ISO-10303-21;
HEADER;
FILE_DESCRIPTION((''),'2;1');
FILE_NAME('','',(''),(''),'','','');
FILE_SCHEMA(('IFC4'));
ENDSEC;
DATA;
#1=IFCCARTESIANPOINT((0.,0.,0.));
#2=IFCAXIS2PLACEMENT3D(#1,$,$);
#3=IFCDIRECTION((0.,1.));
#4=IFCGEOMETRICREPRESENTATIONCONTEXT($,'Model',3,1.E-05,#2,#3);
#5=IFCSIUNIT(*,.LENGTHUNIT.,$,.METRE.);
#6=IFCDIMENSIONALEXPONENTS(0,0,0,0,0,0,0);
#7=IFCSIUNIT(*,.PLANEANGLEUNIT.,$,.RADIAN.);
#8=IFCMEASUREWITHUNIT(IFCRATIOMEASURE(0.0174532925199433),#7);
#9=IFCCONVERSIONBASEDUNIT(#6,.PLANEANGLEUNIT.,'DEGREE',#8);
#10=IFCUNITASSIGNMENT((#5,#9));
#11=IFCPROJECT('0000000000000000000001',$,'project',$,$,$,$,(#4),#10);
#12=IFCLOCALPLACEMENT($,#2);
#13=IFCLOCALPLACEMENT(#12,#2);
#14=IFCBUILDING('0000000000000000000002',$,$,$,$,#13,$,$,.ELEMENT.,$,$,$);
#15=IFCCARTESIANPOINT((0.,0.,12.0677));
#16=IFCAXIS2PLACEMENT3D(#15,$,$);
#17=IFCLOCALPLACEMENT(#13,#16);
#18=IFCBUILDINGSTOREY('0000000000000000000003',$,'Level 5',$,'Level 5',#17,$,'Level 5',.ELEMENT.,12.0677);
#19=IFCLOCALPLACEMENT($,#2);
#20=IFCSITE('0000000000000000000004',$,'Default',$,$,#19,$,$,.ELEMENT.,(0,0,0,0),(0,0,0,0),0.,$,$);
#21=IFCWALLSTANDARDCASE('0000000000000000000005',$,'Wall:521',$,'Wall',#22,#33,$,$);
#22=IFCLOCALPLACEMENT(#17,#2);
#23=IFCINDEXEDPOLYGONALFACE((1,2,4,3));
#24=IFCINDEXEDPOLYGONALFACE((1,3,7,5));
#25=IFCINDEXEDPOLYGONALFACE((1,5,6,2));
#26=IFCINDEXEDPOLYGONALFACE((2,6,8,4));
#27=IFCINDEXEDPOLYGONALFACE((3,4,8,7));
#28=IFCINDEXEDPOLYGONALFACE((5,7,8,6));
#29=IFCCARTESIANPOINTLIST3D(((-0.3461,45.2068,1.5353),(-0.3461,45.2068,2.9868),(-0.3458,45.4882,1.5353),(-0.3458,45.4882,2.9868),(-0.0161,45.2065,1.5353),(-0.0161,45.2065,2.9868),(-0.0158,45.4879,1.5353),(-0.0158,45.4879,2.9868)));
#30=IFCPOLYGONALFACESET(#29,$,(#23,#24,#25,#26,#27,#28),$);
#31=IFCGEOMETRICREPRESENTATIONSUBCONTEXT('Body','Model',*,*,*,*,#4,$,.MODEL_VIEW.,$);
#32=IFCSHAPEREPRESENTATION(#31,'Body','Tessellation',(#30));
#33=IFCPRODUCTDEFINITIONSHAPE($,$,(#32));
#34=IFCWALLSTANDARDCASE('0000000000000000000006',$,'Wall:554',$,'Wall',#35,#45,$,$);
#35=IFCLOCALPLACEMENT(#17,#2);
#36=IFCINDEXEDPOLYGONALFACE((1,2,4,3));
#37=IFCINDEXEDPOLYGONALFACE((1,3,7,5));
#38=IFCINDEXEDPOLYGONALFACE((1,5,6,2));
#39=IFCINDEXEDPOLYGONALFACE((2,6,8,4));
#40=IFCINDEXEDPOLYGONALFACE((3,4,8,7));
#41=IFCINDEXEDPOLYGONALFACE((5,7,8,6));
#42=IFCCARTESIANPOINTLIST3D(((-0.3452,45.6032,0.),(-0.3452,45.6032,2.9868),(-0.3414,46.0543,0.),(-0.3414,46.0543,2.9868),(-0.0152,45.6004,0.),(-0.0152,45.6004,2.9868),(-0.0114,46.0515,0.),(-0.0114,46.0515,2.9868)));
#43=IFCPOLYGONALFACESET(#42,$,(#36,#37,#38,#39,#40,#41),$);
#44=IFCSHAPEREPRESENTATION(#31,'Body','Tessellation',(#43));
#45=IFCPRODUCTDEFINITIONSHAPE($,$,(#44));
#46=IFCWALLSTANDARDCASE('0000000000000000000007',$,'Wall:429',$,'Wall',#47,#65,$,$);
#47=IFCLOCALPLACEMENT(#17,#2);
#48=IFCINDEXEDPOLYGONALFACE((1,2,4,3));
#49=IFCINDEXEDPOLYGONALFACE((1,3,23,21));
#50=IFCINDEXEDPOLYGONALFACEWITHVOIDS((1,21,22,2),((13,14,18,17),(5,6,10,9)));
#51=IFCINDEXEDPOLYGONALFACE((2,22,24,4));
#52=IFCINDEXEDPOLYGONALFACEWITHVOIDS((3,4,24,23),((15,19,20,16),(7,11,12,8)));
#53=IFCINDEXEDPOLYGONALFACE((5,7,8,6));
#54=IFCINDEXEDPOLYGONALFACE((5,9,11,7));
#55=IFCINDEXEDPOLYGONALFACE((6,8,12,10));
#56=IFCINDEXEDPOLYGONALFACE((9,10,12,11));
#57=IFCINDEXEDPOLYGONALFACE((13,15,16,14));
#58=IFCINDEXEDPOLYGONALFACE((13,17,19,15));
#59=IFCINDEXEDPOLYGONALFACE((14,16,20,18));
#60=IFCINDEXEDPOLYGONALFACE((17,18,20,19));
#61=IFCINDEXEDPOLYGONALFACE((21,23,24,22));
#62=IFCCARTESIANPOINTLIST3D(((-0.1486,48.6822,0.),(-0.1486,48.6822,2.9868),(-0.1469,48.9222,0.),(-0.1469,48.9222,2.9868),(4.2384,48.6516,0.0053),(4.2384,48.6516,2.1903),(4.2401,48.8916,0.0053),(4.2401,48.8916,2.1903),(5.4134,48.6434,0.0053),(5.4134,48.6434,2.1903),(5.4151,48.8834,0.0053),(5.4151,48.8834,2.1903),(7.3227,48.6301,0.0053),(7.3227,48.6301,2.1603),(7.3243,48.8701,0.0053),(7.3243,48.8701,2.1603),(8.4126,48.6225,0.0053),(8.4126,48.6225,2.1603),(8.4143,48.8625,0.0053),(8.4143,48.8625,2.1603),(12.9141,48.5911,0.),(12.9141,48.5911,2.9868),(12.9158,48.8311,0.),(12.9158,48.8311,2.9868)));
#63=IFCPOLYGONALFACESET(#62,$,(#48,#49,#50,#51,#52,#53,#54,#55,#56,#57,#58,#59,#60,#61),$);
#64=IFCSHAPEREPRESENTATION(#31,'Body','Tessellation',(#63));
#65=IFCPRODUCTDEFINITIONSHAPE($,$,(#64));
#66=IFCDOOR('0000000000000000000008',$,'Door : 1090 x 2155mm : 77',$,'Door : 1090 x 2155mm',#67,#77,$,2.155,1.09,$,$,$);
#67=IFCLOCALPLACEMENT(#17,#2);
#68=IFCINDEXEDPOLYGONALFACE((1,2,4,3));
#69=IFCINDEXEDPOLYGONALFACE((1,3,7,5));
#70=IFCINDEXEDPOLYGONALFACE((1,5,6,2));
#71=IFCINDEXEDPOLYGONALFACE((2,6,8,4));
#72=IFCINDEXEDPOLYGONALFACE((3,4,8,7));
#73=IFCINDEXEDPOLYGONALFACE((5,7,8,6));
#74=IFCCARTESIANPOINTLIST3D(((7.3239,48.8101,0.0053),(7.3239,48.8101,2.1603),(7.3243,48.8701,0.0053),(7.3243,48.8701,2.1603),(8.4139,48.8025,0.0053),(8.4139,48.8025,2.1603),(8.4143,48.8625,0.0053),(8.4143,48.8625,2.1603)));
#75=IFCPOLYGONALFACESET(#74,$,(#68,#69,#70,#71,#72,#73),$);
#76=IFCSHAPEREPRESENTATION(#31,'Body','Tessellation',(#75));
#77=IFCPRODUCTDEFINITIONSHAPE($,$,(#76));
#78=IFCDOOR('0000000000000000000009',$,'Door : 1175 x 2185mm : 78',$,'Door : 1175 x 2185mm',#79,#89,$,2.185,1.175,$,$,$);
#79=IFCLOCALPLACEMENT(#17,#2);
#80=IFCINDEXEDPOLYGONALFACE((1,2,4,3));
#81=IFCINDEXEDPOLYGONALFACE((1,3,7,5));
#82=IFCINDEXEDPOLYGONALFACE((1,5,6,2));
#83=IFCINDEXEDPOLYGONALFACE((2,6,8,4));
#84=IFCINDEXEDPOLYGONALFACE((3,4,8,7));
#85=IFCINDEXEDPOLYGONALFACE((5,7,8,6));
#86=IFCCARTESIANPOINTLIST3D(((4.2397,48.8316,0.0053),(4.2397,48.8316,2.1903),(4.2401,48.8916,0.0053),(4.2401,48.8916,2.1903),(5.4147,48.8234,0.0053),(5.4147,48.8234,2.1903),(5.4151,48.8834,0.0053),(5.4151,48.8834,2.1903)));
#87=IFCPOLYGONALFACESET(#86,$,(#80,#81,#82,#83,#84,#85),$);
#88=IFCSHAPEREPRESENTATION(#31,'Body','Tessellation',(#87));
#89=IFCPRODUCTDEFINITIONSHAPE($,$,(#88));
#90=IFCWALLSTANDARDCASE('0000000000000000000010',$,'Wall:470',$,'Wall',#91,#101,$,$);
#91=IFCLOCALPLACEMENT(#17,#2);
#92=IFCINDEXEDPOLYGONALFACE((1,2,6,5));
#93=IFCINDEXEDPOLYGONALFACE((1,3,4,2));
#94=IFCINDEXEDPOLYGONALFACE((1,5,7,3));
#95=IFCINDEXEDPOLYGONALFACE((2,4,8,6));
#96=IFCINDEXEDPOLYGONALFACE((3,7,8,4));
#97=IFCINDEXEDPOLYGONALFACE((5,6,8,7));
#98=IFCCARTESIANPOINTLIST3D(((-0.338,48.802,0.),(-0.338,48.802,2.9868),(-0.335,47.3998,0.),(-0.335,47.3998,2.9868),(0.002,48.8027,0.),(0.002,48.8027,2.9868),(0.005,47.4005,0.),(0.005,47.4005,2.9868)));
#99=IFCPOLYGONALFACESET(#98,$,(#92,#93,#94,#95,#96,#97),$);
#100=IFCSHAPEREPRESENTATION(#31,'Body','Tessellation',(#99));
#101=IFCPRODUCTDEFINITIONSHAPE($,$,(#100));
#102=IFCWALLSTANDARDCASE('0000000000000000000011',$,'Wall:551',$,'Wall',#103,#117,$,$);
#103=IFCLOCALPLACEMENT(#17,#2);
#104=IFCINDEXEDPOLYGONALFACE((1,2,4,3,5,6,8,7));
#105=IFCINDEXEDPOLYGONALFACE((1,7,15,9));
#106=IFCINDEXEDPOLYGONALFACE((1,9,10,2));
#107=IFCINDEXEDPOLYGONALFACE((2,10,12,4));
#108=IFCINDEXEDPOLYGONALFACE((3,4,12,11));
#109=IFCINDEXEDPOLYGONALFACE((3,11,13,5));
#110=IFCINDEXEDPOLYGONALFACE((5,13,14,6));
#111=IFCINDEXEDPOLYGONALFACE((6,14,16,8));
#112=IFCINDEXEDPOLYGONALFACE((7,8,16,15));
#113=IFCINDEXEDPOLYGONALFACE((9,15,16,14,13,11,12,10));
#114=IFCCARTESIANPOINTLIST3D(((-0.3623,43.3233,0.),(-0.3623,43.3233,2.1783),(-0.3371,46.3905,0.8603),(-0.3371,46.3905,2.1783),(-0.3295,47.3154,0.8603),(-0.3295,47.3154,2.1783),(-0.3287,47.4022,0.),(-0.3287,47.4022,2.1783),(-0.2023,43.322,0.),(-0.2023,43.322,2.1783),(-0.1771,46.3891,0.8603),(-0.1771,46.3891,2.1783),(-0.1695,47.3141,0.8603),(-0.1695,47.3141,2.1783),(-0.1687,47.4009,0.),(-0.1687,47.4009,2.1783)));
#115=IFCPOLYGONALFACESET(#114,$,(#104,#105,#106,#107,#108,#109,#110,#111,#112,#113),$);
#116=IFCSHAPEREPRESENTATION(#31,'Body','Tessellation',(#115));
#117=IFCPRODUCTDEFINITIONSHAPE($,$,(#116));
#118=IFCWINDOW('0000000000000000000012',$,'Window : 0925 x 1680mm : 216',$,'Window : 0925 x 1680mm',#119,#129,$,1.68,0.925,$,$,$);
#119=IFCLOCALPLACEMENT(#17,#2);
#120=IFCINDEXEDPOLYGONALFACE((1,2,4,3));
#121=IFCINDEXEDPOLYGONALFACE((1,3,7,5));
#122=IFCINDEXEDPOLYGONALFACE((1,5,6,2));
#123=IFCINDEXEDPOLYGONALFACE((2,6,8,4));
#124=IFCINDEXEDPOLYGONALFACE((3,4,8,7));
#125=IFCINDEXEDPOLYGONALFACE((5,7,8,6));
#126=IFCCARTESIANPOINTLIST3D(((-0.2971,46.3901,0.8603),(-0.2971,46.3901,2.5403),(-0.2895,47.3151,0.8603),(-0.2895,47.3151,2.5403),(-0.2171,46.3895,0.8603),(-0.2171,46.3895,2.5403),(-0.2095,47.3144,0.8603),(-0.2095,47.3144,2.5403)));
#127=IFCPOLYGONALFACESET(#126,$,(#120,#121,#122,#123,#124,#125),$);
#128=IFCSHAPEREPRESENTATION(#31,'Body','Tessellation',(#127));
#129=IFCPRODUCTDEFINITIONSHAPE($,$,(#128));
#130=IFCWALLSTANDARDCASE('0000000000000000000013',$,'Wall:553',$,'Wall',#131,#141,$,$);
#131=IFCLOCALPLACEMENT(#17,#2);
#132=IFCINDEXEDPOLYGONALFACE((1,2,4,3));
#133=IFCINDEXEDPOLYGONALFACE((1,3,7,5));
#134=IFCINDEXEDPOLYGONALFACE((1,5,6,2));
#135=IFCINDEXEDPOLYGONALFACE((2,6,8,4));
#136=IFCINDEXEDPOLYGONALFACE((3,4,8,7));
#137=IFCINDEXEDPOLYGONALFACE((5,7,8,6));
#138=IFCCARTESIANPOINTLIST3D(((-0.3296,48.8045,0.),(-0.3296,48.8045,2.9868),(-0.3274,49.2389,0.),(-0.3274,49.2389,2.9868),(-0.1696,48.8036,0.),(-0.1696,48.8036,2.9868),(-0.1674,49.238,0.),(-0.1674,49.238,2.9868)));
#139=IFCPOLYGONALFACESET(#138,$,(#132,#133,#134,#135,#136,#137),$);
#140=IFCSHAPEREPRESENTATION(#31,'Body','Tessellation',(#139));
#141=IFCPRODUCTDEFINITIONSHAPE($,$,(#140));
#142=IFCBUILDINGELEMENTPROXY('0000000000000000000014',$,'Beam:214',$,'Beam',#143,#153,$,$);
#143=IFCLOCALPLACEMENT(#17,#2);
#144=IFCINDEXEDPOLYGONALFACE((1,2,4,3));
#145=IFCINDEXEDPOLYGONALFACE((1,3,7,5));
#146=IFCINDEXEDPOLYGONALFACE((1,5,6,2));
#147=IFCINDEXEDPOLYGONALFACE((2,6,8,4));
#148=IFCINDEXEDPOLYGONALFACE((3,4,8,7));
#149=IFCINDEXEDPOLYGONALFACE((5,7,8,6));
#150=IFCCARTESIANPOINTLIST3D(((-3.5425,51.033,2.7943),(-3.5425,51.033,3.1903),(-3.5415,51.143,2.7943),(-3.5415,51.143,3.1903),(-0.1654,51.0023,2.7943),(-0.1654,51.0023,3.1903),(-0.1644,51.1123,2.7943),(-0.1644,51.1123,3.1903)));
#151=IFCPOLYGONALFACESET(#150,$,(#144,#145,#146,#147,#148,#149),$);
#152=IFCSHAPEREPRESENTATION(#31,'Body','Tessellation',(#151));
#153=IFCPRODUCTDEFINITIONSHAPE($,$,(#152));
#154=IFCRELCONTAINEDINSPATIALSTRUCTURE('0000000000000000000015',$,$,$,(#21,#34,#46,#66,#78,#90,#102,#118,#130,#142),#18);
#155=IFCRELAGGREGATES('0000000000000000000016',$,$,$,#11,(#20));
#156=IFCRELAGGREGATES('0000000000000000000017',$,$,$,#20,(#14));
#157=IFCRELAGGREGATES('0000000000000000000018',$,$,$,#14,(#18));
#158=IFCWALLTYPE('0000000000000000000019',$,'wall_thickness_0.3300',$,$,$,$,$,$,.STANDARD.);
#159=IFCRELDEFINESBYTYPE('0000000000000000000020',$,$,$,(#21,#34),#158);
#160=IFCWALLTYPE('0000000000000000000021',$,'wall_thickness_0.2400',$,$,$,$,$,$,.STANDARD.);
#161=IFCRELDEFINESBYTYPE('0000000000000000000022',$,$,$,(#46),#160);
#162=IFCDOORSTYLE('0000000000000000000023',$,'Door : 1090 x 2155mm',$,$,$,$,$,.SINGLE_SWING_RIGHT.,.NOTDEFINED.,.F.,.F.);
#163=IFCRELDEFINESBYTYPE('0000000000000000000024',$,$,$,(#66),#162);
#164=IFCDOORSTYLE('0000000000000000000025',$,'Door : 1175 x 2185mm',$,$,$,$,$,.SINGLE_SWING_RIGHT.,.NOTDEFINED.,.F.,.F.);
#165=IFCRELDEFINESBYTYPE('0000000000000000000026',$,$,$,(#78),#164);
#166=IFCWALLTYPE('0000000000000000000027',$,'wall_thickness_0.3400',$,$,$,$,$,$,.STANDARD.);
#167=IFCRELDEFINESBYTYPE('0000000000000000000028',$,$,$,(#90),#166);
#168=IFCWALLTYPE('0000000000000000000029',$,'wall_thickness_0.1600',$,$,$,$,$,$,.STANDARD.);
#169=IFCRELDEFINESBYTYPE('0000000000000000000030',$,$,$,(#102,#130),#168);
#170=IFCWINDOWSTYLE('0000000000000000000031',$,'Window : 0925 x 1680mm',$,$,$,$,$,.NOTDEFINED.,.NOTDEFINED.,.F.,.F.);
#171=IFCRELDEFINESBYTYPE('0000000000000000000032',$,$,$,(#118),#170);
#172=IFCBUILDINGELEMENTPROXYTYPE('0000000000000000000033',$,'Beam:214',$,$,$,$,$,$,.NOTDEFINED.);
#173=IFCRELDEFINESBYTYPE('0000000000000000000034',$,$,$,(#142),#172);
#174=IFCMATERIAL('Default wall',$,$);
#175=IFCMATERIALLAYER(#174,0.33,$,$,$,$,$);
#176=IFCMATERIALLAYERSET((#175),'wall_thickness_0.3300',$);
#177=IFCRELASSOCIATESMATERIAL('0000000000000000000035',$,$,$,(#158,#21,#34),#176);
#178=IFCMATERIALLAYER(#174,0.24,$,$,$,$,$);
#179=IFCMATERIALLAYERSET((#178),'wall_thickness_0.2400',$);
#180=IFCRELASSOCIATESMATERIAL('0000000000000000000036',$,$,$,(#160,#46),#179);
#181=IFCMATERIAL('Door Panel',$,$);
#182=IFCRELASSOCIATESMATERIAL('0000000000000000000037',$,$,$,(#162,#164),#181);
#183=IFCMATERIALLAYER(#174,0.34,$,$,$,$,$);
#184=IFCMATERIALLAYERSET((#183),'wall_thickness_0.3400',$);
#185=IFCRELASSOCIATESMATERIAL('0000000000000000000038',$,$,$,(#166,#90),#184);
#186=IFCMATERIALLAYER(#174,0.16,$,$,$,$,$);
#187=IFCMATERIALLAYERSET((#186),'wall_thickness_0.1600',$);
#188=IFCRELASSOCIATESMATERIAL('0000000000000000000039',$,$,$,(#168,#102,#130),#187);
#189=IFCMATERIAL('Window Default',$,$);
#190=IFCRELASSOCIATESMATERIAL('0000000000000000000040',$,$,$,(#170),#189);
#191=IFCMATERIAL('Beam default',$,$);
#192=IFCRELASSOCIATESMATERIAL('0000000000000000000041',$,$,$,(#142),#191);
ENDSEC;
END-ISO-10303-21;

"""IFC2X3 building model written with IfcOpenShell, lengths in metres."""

from ifc_helpers import new_model, entity, si_unit, converted_unit, direction, frame, frame_2d, origin, origin_2d_with_axis, place, context, subcontext, project, spatial, polyline, rectangle, outline, extrude, source, transform, mapped, material, layer, layer_set, layer_usage, type_object, type_shapes, element, fill, save


model = new_model("IFC2X3")

# Units and contexts
model_context = context("Model", 3, precision=1e-05, world=origin(), true_north=direction((0.0, 1.0)))
body_context = subcontext(model_context, "Body", "Model", "MODEL_VIEW")
ifc_project = project(units=[si_unit("LENGTHUNIT", "METRE"), converted_unit("PLANEANGLEUNIT", "DEGREE", entity("IfcRatioMeasure", 0.0174532925199433), si_unit("PLANEANGLEUNIT", "RADIAN"), dimensions=[0, 0, 0, 0, 0, 0, 0])], contexts=[model_context])

# Site, building, storey
site_placement = place(None, origin())
site = spatial("IfcSite", under=ifc_project, at=site_placement, Name="Default", CompositionType="ELEMENT", RefLatitude=(0, 0, 0, 0), RefLongitude=(0, 0, 0, 0), RefElevation=0.0)
placement_1 = place(None, origin())
building_placement = place(placement_1, origin())
building = spatial("IfcBuilding", under=site, at=building_placement, CompositionType="ELEMENT")
storey_placement = place(building_placement, frame((0.0, 0.0, 12.0677)))
storey = spatial("IfcBuildingStorey", under=building, at=storey_placement, Name="Level 5", ObjectType="Level 5", LongName="Level 5", CompositionType="ELEMENT", Elevation=12.0677)

# Shared definitions
ifc_material_1 = material(Name="Default wall")

# Shared definitions
ifc_layer_1 = layer(ifc_material_1, 0.33)
ifc_layer_set_1 = layer_set([ifc_layer_1], Name="wall_thickness_0.3300")
ifc_layer_usage_1 = layer_usage(ifc_layer_set_1, "AXIS2", "POSITIVE", -0.165)
wall_type_1 = type_object("IfcWallType", Name="wall_thickness_0.3300", PredefinedType="STANDARD", material=ifc_layer_set_1)
ifc_material_2 = material(Name="Window Default")

# Walls
placement_2 = place(building_placement, frame((0.0, 0.0, 13.603)))
wall_1_placement = place(placement_2, frame((-0.1808, 45.488, 0.0), z_axis=(0.0, 0.0, 1.0), x_axis=(-0.001081, -0.999999, 0.0)))
element("IfcWallStandardCase", 1, at=wall_1_placement, inside=storey, type_object=wall_type_1, material=ifc_layer_usage_1, Name="Wall:521", ObjectType="Wall", context=body_context, shape_type="SweptSolid", body=[
    extrude(outline(polyline([(0.2814, -0.165), (0.2814, 0.165), (0.0, 0.165), (0.0, -0.165), (0.2814, -0.165)])), origin(), (0.0, 0.0, 1.0), 1.4515),
])
wall_2_placement = place(storey_placement, frame((-0.1764, 46.0529, 0.0), z_axis=(0.0, 0.0, 1.0), x_axis=(-0.008507, -0.999964, 0.0)))
element("IfcWallStandardCase", 2, at=wall_2_placement, inside=storey, type_object=wall_type_1, material=ifc_layer_usage_1, Name="Wall:554", ObjectType="Wall", context=body_context, shape_type="SweptSolid", body=[
    extrude(outline(polyline([(0.4511, -0.165), (0.4511, 0.165), (0.0, 0.165), (0.0, -0.165), (0.4511, -0.165)])), origin(), (0.0, 0.0, 1.0), 2.9868),
])

# Wall, openings, doors
ifc_layer_2 = layer(ifc_material_1, 0.24)
ifc_layer_set_2 = layer_set([ifc_layer_2], Name="wall_thickness_0.2400")
ifc_layer_usage_2 = layer_usage(ifc_layer_set_2, "AXIS2", "POSITIVE", -0.12)
wall_type_2 = type_object("IfcWallType", Name="wall_thickness_0.2400", PredefinedType="STANDARD", material=ifc_layer_set_2)
wall_3_placement = place(storey_placement, frame((-0.1477, 48.8022, 0.0), z_axis=(0.0, 0.0, 1.0), x_axis=(0.999976, -0.006979, 0.0)))
wall_3 = element("IfcWallStandardCase", 3, at=wall_3_placement, inside=storey, type_object=wall_type_2, material=ifc_layer_usage_2, Name="Wall:429", ObjectType="Wall", context=body_context, shape_type="SweptSolid", body=[
    extrude(outline(polyline([(13.063, -0.12), (13.063, 0.12), (0.0, 0.12), (0.0, -0.12), (13.063, -0.12)])), origin(), (0.0, 0.0, 1.0), 2.9868),
])
opening_1_placement = place(wall_3_placement, frame((7.4714, -0.12, 0.0053)))
opening_1 = element("IfcOpeningElement", 4, at=opening_1_placement, cuts=wall_3, ObjectType="Opening", context=body_context, shape_type="SweptSolid", body=[
    extrude(rectangle(XDim=1.09, YDim=2.155, at=frame_2d((1.0775, 0.545), x_axis=(0.0, 1.0))), frame((0.0, 0.0, 0.0), z_axis=(0.0, 1.0, 0.0), x_axis=(0.0, 0.0, 1.0)), (0.0, 0.0, 1.0), 0.24),
])
opening_2_placement = place(wall_3_placement, frame((4.3871, -0.12, 0.0053)))
opening_2 = element("IfcOpeningElement", 5, at=opening_2_placement, cuts=wall_3, ObjectType="Opening", context=body_context, shape_type="SweptSolid", body=[
    extrude(rectangle(XDim=1.175, YDim=2.185, at=frame_2d((1.0925, 0.5875), x_axis=(0.0, 1.0))), frame((0.0, 0.0, 0.0), z_axis=(0.0, 1.0, 0.0), x_axis=(0.0, 0.0, 1.0)), (0.0, 0.0, 1.0), 0.24),
])
ifc_material_3 = material(Name="Door Panel")
door_style_1 = type_object("IfcDoorStyle", Name="Door : 1090 x 2155mm", ConstructionType="NOTDEFINED", OperationType="SINGLE_SWING_RIGHT", ParameterTakesPrecedence=False, Sizeable=False, material=ifc_material_3)
shared_shape_1 = source(origin(), body_context, "Body", "SweptSolid", [
    extrude(rectangle(XDim=0.06, YDim=1.09, at=origin_2d_with_axis()), frame((0.545, 0.21, 0.0), z_axis=(0.0, 0.0, 1.0), x_axis=(0.0, 1.0, 0.0)), (0.0, 0.0, 1.0), 2.155),
])
type_shapes(door_style_1, [shared_shape_1])
door_1_placement = place(opening_1_placement, origin())
door_1 = element("IfcDoor", 6, at=door_1_placement, inside=storey, type_object=door_style_1, Name="Door : 1090 x 2155mm : 77", ObjectType="Door : 1090 x 2155mm", OverallHeight=2.155, OverallWidth=1.09, context=body_context, shape_type="MappedRepresentation", body=[
    mapped(shared_shape_1, transform((0.0, 0.0, 0.0), scale=1.0)),
])
fill(opening_1, door_1)
door_style_2 = type_object("IfcDoorStyle", Name="Door : 1175 x 2185mm", ConstructionType="NOTDEFINED", OperationType="SINGLE_SWING_RIGHT", ParameterTakesPrecedence=False, Sizeable=False, material=ifc_material_3)
shared_shape_2 = source(origin(), body_context, "Body", "SweptSolid", [
    extrude(rectangle(XDim=0.06, YDim=1.175, at=origin_2d_with_axis()), frame((0.5875, 0.21, 0.0), z_axis=(0.0, 0.0, 1.0), x_axis=(0.0, 1.0, 0.0)), (0.0, 0.0, 1.0), 2.185),
])
type_shapes(door_style_2, [shared_shape_2])
door_2_placement = place(opening_2_placement, origin())
door_2 = element("IfcDoor", 7, at=door_2_placement, inside=storey, type_object=door_style_2, Name="Door : 1175 x 2185mm : 78", ObjectType="Door : 1175 x 2185mm", OverallHeight=2.185, OverallWidth=1.175, context=body_context, shape_type="MappedRepresentation", body=[
    mapped(shared_shape_2, transform((0.0, 0.0, 0.0), scale=1.0)),
])
fill(opening_2, door_2)

# Wall
ifc_layer_3 = layer(ifc_material_1, 0.34)
ifc_layer_set_3 = layer_set([ifc_layer_3], Name="wall_thickness_0.3400")
ifc_layer_usage_3 = layer_usage(ifc_layer_set_3, "AXIS2", "POSITIVE", -0.17)
wall_type_3 = type_object("IfcWallType", Name="wall_thickness_0.3400", PredefinedType="STANDARD", material=ifc_layer_set_3)
wall_4_placement = place(storey_placement, frame((-0.168, 48.8024, 0.0), z_axis=(0.0, 0.0, 1.0), x_axis=(0.002158, -0.999998, 0.0)))
element("IfcWallStandardCase", 8, at=wall_4_placement, inside=storey, type_object=wall_type_3, material=ifc_layer_usage_3, Name="Wall:470", ObjectType="Wall", context=body_context, shape_type="SweptSolid", body=[
    extrude(outline(polyline([(1.4022, -0.17), (1.4022, 0.17), (0.0, 0.17), (0.0, -0.17), (1.4022, -0.17)])), origin(), (0.0, 0.0, 1.0), 2.9868),
])

# Wall, opening, window
ifc_layer_4 = layer(ifc_material_1, 0.16)
ifc_layer_set_4 = layer_set([ifc_layer_4], Name="wall_thickness_0.1600")
ifc_layer_usage_4 = layer_usage(ifc_layer_set_4, "AXIS2", "POSITIVE", -0.08)
wall_type_4 = type_object("IfcWallType", Name="wall_thickness_0.1600", PredefinedType="STANDARD", material=ifc_layer_set_4)
wall_5_placement = place(storey_placement, frame((-0.2487, 47.4016, 0.0), z_axis=(0.0, 0.0, 1.0), x_axis=(-0.008222, -0.999966, 0.0)))
wall_5 = element("IfcWallStandardCase", 9, at=wall_5_placement, inside=storey, type_object=wall_type_4, material=ifc_layer_usage_4, Name="Wall:551", ObjectType="Wall", context=body_context, shape_type="SweptSolid", body=[
    extrude(outline(polyline([(4.0791, -0.08), (4.0791, 0.08), (0.0, 0.08), (0.0, -0.08), (4.0791, -0.08)])), origin(), (0.0, 0.0, 1.0), 2.1783),
])
opening_3_placement = place(wall_5_placement, frame((0.0868, -0.08, 0.8603)))
opening_3 = element("IfcOpeningElement", 10, at=opening_3_placement, cuts=wall_5, ObjectType="Opening", context=body_context, shape_type="SweptSolid", body=[
    extrude(rectangle(XDim=0.925, YDim=1.68, at=frame_2d((0.84, 0.4625), x_axis=(0.0, 1.0))), frame((0.0, 0.0, 0.0), z_axis=(0.0, 1.0, 0.0), x_axis=(0.0, 0.0, 1.0)), (0.0, 0.0, 1.0), 0.16),
])
window_style_1 = type_object("IfcWindowStyle", Name="Window : 0925 x 1680mm", ConstructionType="NOTDEFINED", OperationType="NOTDEFINED", ParameterTakesPrecedence=False, Sizeable=False, material=ifc_material_2)
shared_shape_3 = source(origin(), body_context, "Body", "SweptSolid", [
    extrude(rectangle(XDim=0.08, YDim=0.925, at=origin_2d_with_axis()), frame((0.4625, 0.08, 0.0), z_axis=(0.0, 0.0, 1.0), x_axis=(0.0, 1.0, 0.0)), (0.0, 0.0, 1.0), 1.68),
])
type_shapes(window_style_1, [shared_shape_3])
window_1_placement = place(opening_3_placement, origin())
window_1 = element("IfcWindow", 11, at=window_1_placement, inside=storey, type_object=window_style_1, Name="Window : 0925 x 1680mm : 216", ObjectType="Window : 0925 x 1680mm", OverallHeight=1.68, OverallWidth=0.925, context=body_context, shape_type="MappedRepresentation", body=[
    mapped(shared_shape_3, transform((0.0, 0.0, 0.0), scale=1.0)),
])
fill(opening_3, window_1)

# Wall
wall_6_placement = place(storey_placement, frame((-0.2474, 49.2385, 0.0), z_axis=(0.0, 0.0, 1.0), x_axis=(-0.005207, -0.999986, 0.0)))
element("IfcWallStandardCase", 12, at=wall_6_placement, inside=storey, type_object=wall_type_4, material=ifc_layer_usage_4, Name="Wall:553", ObjectType="Wall", context=body_context, shape_type="SweptSolid", body=[
    extrude(outline(polyline([(0.4344, -0.08), (0.4344, 0.08), (0.0, 0.08), (0.0, -0.08), (0.4344, -0.08)])), origin(), (0.0, 0.0, 1.0), 2.9868),
])

# Building element proxy
ifc_material_4 = material(Name="Beam default")
building_element_proxy_type_1 = type_object("IfcBuildingElementProxyType", Name="Beam:214", PredefinedType="NOTDEFINED")
shared_shape_4 = source(origin(), body_context, "Body", "SweptSolid", [
    extrude(outline(polyline([(3.3773, -0.055), (3.3773, 0.055), (0.0, 0.055), (0.0, -0.055), (3.3773, -0.055)])), origin(), (0.0, 0.0, 1.0), 0.396),
])
type_shapes(building_element_proxy_type_1, [shared_shape_4])
placement_3 = place(building_placement, frame((0.0, 0.0, 14.862)))
proxy_1_placement = place(placement_3, frame((-3.542, 51.088, 0.0), z_axis=(0.0, 0.0, 1.0), x_axis=(0.999959, -0.009098, 0.0)))
element("IfcBuildingElementProxy", 13, at=proxy_1_placement, inside=storey, type_object=building_element_proxy_type_1, material=ifc_material_4, Name="Beam:214", ObjectType="Beam", context=body_context, shape_type="MappedRepresentation", body=[
    mapped(shared_shape_4, transform((0.0, 0.0, 0.0), scale=1.0)),
])

save(model, "model.ifc")
